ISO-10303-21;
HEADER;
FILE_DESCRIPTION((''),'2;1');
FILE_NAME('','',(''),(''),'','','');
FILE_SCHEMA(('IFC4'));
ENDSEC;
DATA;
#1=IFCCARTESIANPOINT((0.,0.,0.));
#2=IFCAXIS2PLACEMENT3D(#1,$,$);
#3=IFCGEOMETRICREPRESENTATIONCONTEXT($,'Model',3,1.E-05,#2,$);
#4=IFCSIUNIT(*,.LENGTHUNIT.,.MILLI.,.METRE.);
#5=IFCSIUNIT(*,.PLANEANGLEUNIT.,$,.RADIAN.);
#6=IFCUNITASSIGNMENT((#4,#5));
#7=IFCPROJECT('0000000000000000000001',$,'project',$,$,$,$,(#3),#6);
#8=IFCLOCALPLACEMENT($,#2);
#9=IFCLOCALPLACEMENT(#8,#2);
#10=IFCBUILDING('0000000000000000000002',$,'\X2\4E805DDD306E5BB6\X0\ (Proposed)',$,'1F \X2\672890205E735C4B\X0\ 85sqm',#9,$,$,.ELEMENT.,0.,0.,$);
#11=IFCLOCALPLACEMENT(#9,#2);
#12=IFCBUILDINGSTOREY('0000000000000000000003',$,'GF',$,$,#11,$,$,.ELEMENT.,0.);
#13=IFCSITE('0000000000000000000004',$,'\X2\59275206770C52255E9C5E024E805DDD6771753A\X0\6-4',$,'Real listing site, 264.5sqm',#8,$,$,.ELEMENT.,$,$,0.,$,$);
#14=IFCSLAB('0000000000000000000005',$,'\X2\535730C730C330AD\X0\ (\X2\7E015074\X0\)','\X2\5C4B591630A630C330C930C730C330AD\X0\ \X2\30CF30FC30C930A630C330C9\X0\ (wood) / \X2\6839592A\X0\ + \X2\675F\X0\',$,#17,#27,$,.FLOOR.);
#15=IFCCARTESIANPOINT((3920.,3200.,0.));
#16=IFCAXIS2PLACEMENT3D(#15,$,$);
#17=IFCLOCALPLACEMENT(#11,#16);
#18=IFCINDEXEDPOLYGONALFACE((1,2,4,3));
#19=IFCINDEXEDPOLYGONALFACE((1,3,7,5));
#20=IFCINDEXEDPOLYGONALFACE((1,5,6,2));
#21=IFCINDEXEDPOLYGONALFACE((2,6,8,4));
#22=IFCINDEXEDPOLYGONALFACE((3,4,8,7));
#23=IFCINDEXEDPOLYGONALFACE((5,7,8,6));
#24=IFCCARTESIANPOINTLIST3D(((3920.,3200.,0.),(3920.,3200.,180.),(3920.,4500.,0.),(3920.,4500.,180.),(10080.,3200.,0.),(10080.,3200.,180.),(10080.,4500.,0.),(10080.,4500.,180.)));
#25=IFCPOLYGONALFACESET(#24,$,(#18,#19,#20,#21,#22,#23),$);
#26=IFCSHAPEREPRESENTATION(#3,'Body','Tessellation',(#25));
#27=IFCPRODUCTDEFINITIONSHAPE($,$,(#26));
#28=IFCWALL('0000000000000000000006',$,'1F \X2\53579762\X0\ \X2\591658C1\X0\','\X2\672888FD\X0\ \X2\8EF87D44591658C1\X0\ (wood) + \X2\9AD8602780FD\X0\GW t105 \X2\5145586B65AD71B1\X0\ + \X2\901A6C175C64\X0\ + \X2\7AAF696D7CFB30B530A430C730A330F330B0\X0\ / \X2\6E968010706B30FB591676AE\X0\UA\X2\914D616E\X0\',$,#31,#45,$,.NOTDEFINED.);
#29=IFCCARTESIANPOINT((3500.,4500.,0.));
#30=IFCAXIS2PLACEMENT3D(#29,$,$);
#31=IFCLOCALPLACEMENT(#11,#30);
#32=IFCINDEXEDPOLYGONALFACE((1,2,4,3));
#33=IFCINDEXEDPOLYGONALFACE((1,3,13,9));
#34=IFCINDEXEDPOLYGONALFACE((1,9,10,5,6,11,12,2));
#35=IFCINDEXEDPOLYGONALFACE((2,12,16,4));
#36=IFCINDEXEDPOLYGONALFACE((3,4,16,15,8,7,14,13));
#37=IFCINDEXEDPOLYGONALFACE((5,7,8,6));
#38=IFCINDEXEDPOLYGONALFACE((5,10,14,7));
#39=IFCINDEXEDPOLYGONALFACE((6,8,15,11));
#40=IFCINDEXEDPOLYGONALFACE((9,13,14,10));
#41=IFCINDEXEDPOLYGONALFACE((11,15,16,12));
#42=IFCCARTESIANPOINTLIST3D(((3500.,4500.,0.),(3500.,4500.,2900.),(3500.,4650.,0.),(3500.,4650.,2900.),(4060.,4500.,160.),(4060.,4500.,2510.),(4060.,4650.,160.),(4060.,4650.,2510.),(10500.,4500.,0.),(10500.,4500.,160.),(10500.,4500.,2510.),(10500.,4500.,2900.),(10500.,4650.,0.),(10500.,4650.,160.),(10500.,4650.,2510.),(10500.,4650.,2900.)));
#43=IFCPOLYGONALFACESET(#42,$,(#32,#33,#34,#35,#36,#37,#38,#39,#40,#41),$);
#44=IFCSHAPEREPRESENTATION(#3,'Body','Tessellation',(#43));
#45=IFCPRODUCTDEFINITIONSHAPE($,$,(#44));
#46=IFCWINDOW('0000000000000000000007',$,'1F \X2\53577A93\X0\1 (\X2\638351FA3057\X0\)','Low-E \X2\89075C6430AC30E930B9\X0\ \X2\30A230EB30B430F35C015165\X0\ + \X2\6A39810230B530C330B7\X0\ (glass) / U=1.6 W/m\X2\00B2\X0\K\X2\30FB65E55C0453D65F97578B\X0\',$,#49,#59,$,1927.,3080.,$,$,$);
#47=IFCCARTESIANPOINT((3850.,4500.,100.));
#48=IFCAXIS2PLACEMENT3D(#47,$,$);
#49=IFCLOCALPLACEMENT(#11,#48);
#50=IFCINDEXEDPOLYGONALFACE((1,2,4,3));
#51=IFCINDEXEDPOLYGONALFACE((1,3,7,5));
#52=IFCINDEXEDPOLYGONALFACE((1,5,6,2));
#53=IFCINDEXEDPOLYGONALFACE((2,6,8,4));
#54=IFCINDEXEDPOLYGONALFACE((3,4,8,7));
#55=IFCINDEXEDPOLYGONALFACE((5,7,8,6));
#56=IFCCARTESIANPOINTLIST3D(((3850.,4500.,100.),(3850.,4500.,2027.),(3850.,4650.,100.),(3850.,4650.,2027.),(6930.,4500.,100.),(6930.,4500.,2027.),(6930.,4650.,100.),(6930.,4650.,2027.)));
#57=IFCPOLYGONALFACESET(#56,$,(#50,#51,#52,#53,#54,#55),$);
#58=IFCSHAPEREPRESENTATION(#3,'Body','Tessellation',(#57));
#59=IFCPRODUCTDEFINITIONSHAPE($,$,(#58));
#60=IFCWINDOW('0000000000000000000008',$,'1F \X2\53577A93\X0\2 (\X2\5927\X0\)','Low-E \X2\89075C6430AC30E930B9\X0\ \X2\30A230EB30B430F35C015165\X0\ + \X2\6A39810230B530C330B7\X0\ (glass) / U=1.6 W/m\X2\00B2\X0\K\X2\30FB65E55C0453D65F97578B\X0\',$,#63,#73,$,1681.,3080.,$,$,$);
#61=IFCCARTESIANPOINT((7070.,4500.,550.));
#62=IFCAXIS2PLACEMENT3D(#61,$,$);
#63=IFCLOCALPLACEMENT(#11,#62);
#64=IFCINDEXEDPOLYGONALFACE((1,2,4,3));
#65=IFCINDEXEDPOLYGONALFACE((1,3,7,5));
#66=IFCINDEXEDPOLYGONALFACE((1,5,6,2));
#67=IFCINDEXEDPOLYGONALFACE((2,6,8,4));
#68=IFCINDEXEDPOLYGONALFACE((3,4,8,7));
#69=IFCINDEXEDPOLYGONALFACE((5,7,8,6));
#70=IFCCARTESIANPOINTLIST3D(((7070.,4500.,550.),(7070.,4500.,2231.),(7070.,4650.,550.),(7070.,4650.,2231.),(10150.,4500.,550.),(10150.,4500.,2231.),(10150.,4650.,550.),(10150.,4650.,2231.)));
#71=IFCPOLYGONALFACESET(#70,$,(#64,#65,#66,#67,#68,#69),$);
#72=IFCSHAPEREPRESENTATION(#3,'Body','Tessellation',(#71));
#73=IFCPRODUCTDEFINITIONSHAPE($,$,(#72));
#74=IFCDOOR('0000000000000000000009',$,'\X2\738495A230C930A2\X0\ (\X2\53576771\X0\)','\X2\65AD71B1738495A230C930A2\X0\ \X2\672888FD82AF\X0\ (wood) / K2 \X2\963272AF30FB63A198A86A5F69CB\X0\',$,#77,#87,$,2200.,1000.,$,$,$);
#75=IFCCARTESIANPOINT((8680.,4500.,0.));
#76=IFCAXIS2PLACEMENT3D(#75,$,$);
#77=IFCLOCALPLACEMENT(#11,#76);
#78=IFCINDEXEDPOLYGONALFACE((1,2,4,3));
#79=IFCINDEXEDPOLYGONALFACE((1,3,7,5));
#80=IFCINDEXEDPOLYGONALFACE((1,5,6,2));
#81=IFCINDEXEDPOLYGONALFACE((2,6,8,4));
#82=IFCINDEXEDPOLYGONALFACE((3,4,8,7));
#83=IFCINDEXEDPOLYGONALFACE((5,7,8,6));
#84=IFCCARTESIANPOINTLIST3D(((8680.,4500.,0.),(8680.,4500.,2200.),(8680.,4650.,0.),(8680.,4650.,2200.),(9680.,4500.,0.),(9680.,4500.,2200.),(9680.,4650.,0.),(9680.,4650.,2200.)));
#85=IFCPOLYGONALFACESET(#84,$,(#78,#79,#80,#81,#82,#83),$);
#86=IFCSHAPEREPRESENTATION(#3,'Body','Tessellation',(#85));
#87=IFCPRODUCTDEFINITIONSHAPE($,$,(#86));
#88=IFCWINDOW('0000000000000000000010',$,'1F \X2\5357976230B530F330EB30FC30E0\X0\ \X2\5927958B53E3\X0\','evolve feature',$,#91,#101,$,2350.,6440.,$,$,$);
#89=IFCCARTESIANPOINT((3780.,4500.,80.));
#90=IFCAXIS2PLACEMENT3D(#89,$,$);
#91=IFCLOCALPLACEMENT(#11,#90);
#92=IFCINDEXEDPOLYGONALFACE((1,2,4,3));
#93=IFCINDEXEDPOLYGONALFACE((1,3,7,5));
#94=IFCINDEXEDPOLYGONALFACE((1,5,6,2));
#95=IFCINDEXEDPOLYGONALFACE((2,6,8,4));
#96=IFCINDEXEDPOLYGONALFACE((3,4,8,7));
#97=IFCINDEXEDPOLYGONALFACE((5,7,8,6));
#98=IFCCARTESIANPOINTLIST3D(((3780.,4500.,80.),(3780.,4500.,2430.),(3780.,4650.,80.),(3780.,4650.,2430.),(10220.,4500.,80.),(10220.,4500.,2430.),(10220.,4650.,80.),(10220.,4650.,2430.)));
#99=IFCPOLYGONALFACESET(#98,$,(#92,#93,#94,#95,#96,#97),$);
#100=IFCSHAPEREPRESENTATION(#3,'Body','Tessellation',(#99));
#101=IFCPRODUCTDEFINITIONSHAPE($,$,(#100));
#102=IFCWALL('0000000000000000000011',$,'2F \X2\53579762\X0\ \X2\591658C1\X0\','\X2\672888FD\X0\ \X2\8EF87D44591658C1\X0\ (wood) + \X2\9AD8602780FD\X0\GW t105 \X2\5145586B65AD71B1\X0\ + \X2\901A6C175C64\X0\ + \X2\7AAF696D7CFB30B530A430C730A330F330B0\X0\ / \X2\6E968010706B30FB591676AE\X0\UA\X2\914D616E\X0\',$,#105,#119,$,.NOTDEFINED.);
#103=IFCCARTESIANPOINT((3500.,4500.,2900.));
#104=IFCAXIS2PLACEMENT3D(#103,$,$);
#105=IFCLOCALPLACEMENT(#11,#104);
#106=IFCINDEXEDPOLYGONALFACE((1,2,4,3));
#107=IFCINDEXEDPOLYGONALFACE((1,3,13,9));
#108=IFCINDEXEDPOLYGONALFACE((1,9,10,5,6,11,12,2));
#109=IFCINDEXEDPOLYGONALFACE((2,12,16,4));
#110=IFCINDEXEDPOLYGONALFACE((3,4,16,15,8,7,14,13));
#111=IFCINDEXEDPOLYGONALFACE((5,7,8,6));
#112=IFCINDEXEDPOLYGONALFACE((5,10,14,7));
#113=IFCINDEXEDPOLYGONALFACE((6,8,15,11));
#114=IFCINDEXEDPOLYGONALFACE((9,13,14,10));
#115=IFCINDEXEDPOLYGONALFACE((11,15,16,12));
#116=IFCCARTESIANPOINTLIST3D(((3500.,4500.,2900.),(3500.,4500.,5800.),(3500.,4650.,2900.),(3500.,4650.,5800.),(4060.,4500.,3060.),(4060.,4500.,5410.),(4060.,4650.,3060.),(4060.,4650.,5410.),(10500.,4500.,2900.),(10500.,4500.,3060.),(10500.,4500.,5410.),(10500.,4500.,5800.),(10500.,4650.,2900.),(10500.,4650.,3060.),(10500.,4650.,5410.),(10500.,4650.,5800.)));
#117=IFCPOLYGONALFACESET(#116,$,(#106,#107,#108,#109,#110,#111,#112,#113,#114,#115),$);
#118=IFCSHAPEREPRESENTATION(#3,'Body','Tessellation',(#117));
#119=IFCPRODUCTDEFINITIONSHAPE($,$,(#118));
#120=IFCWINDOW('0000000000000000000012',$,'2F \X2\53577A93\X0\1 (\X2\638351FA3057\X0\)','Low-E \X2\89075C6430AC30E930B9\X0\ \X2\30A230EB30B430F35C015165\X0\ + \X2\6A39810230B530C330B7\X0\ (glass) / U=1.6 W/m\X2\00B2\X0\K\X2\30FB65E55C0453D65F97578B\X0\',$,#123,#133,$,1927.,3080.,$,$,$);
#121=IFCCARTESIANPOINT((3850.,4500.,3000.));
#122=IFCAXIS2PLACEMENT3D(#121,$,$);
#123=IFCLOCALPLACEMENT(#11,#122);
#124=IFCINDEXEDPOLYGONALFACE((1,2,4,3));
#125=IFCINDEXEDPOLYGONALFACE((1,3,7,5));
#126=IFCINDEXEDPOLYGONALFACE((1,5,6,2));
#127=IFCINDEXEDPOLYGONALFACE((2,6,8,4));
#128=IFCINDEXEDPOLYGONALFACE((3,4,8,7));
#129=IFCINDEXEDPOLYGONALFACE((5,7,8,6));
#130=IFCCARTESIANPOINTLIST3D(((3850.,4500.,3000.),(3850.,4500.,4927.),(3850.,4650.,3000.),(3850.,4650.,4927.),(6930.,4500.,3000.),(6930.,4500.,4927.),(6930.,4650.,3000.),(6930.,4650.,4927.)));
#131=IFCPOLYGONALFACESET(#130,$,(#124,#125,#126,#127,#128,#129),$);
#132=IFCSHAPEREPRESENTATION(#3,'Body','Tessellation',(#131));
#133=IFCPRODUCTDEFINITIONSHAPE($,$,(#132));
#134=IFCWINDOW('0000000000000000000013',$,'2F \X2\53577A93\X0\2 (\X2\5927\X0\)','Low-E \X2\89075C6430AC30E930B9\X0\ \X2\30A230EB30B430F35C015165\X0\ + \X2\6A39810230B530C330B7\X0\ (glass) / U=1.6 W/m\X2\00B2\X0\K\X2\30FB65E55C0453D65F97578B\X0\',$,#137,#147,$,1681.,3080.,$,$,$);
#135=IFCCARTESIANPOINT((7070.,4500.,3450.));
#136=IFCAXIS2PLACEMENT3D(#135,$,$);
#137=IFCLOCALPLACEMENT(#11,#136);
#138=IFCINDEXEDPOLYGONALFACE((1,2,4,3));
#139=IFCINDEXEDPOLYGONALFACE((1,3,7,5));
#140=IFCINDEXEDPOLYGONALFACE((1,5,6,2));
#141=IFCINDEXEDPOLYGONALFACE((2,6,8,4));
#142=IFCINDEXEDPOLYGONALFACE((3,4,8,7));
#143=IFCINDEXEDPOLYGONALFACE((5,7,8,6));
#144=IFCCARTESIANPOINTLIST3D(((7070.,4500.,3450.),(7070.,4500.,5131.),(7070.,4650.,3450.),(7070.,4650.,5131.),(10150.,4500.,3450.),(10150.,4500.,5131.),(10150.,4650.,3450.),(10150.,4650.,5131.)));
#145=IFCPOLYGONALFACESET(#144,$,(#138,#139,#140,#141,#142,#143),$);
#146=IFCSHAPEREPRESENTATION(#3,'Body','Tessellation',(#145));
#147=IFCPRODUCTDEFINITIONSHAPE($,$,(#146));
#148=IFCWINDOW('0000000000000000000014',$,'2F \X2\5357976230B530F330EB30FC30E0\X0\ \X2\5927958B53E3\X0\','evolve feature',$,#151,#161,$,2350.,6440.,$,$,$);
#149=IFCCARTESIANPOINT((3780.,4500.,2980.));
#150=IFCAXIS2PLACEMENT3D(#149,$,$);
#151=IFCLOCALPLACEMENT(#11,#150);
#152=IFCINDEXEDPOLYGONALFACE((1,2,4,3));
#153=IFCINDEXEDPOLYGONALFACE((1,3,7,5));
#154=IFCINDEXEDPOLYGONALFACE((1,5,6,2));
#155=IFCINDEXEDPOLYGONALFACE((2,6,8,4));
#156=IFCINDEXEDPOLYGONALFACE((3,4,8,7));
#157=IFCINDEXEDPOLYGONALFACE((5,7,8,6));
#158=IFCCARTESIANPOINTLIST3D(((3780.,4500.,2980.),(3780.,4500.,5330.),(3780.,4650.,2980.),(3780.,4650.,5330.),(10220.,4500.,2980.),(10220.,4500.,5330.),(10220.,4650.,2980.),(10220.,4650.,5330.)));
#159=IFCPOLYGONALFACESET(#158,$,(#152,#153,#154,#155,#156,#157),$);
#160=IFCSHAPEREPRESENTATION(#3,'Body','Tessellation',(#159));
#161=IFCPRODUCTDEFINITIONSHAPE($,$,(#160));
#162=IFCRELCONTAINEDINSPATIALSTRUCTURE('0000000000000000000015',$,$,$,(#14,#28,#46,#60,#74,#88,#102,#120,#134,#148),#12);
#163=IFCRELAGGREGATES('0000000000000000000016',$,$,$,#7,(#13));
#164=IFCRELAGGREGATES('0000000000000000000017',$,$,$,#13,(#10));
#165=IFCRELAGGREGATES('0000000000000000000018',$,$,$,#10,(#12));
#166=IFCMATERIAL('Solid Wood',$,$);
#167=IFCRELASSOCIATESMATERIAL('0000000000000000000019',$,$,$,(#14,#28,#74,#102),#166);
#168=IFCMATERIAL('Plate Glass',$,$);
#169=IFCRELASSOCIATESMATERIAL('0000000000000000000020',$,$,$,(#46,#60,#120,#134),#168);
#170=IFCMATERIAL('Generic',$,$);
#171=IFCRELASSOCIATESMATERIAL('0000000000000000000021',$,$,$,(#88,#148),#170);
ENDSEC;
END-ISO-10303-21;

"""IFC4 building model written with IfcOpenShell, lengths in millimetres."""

from ifc_helpers import new_model, si_unit, frame, frame_2d, origin, place, context, project, spatial, rectangle, extrude, material, element, fill, save


model = new_model("IFC4")

# Units and contexts
model_context = context("Model", 3, precision=1e-05, world=origin())
ifc_project = project(units=[si_unit("LENGTHUNIT", "METRE", prefix="MILLI"), si_unit("PLANEANGLEUNIT", "RADIAN")], contexts=[model_context])

# Site, building, storey
site_placement = place(None, origin())
site = spatial("IfcSite", under=ifc_project, at=site_placement, Name="大分県別府市亀川東町6-4", ObjectType="Real listing site, 264.5sqm", CompositionType="ELEMENT", RefElevation=0.0)
building_placement = place(site_placement, origin())
building = spatial("IfcBuilding", under=site, at=building_placement, Name="亀川の家 (Proposed)", ObjectType="1F 木造平屋 85sqm", CompositionType="ELEMENT", ElevationOfRefHeight=0.0, ElevationOfTerrain=0.0)
storey_placement = place(building_placement, origin())
storey = spatial("IfcBuildingStorey", under=building, at=storey_placement, Name="GF", CompositionType="ELEMENT", Elevation=0.0)

# Slab
ifc_material_1 = material(Name="Solid Wood")
slab_1_placement = place(storey_placement, frame((3920.0, 3200.0, 0.0)))
element("IfcSlab", 1, at=slab_1_placement, inside=storey, material=ifc_material_1, Name="南デッキ (縁側)", Description="屋外ウッドデッキ ハードウッド (wood) / 根太 + 束", PredefinedType="FLOOR", context=model_context, shape_type="SweptSolid", body=[
    extrude(rectangle(XDim=6160.0, YDim=1300.0, at=frame_2d((3080.0, 650.0))), frame((3920.0, 3200.0, 0.0)), (0.0, 0.0, 1.0), 180.0),
])
ifc_material_2 = material(Name="Generic")

# Wall, openings, windows, door
wall_1_placement = place(storey_placement, frame((3500.0, 4500.0, 0.0)))
wall_1 = element("IfcWall", 2, at=wall_1_placement, inside=storey, material=ifc_material_1, Name="1F 南面 外壁", Description="木製 軸組外壁 (wood) + 高性能GW t105 充填断熱 + 通気層 + 窯業系サイディング / 準耐火・外皮UA配慮", PredefinedType="NOTDEFINED", context=model_context, shape_type="SweptSolid", body=[
    extrude(rectangle(XDim=7000.0, YDim=150.0, at=frame_2d((3500.0, 75.0))), frame((3500.0, 4500.0, 0.0)), (0.0, 0.0, 1.0), 2900.0),
])
opening_1_placement = place(storey_placement, frame((3850.0, 4500.0, 100.0)))
opening_1 = element("IfcOpeningElement", 3, at=opening_1_placement, cuts=wall_1, PredefinedType="NOTDEFINED", context=model_context, shape_type="SweptSolid", body=[
    extrude(rectangle(XDim=3080.0, YDim=150.0, at=frame_2d((1540.0, 75.0))), frame((3850.0, 4500.0, 100.0)), (0.0, 0.0, 1.0), 1927.0),
])
opening_2_placement = place(storey_placement, frame((7070.0, 4500.0, 550.0)))
opening_2 = element("IfcOpeningElement", 4, at=opening_2_placement, cuts=wall_1, PredefinedType="NOTDEFINED", context=model_context, shape_type="SweptSolid", body=[
    extrude(rectangle(XDim=3080.0, YDim=150.0, at=frame_2d((1540.0, 75.0))), frame((7070.0, 4500.0, 550.0)), (0.0, 0.0, 1.0), 1681.0),
])
opening_3_placement = place(storey_placement, frame((8680.0, 4500.0, 0.0)))
opening_3 = element("IfcOpeningElement", 5, at=opening_3_placement, cuts=wall_1, PredefinedType="NOTDEFINED", context=model_context, shape_type="SweptSolid", body=[
    extrude(rectangle(XDim=1000.0, YDim=150.0, at=frame_2d((500.0, 75.0))), frame((8680.0, 4500.0, 0.0)), (0.0, 0.0, 1.0), 2200.0),
])
opening_4_placement = place(storey_placement, frame((3780.0, 4500.0, 80.0)))
opening_4 = element("IfcOpeningElement", 6, at=opening_4_placement, cuts=wall_1, PredefinedType="NOTDEFINED", context=model_context, shape_type="SweptSolid", body=[
    extrude(rectangle(XDim=6440.0, YDim=150.0, at=frame_2d((3220.0, 75.0))), frame((3780.0, 4500.0, 80.0)), (0.0, 0.0, 1.0), 2350.0),
])
ifc_material_3 = material(Name="Plate Glass")
window_1_placement = place(storey_placement, frame((3850.0, 4500.0, 100.0)))
window_1 = element("IfcWindow", 7, at=window_1_placement, inside=storey, material=ifc_material_3, Name="1F 南窓1 (掃出し)", Description="Low-E 複層ガラス アルゴン封入 + 樹脂サッシ (glass) / U=1.6 W/m²K・日射取得型", OverallHeight=1927.0, OverallWidth=3080.0, context=model_context, shape_type="SweptSolid", body=[
    extrude(rectangle(XDim=3080.0, YDim=150.0, at=frame_2d((1540.0, 75.0))), frame((3850.0, 4500.0, 100.0)), (0.0, 0.0, 1.0), 1927.0),
])
fill(opening_1, window_1)
window_2_placement = place(storey_placement, frame((7070.0, 4500.0, 550.0)))
window_2 = element("IfcWindow", 8, at=window_2_placement, inside=storey, material=ifc_material_3, Name="1F 南窓2 (大)", Description="Low-E 複層ガラス アルゴン封入 + 樹脂サッシ (glass) / U=1.6 W/m²K・日射取得型", OverallHeight=1681.0, OverallWidth=3080.0, context=model_context, shape_type="SweptSolid", body=[
    extrude(rectangle(XDim=3080.0, YDim=150.0, at=frame_2d((1540.0, 75.0))), frame((7070.0, 4500.0, 550.0)), (0.0, 0.0, 1.0), 1681.0),
])
fill(opening_2, window_2)
door_placement = place(storey_placement, frame((8680.0, 4500.0, 0.0)))
door = element("IfcDoor", 9, at=door_placement, inside=storey, material=ifc_material_1, Name="玄関ドア (南東)", Description="断熱玄関ドア 木製芯 (wood) / K2 防犯・採風機構", OverallHeight=2200.0, OverallWidth=1000.0, context=model_context, shape_type="SweptSolid", body=[
    extrude(rectangle(XDim=1000.0, YDim=150.0, at=frame_2d((500.0, 75.0))), frame((8680.0, 4500.0, 0.0)), (0.0, 0.0, 1.0), 2200.0),
])
fill(opening_3, door)
window_3_placement = place(storey_placement, frame((3780.0, 4500.0, 80.0)))
window_3 = element("IfcWindow", 10, at=window_3_placement, inside=storey, material=ifc_material_2, Name="1F 南面サンルーム 大開口", Description="evolve feature", OverallHeight=2350.0, OverallWidth=6440.0, context=model_context, shape_type="SweptSolid", body=[
    extrude(rectangle(XDim=6440.0, YDim=150.0, at=frame_2d((3220.0, 75.0))), frame((3780.0, 4500.0, 80.0)), (0.0, 0.0, 1.0), 2350.0),
])
fill(opening_4, window_3)

# Wall, openings, windows
wall_2_placement = place(storey_placement, frame((3500.0, 4500.0, 2900.0)))
wall_2 = element("IfcWall", 11, at=wall_2_placement, inside=storey, material=ifc_material_1, Name="2F 南面 外壁", Description="木製 軸組外壁 (wood) + 高性能GW t105 充填断熱 + 通気層 + 窯業系サイディング / 準耐火・外皮UA配慮", PredefinedType="NOTDEFINED", context=model_context, shape_type="SweptSolid", body=[
    extrude(rectangle(XDim=7000.0, YDim=150.0, at=frame_2d((3500.0, 75.0))), frame((3500.0, 4500.0, 2900.0)), (0.0, 0.0, 1.0), 2900.0),
])
opening_5_placement = place(storey_placement, frame((3850.0, 4500.0, 3000.0)))
opening_5 = element("IfcOpeningElement", 12, at=opening_5_placement, cuts=wall_2, PredefinedType="NOTDEFINED", context=model_context, shape_type="SweptSolid", body=[
    extrude(rectangle(XDim=3080.0, YDim=150.0, at=frame_2d((1540.0, 75.0))), frame((3850.0, 4500.0, 3000.0)), (0.0, 0.0, 1.0), 1927.0),
])
opening_6_placement = place(storey_placement, frame((7070.0, 4500.0, 3450.0)))
opening_6 = element("IfcOpeningElement", 13, at=opening_6_placement, cuts=wall_2, PredefinedType="NOTDEFINED", context=model_context, shape_type="SweptSolid", body=[
    extrude(rectangle(XDim=3080.0, YDim=150.0, at=frame_2d((1540.0, 75.0))), frame((7070.0, 4500.0, 3450.0)), (0.0, 0.0, 1.0), 1681.0),
])
opening_7_placement = place(storey_placement, frame((3780.0, 4500.0, 2980.0)))
opening_7 = element("IfcOpeningElement", 14, at=opening_7_placement, cuts=wall_2, PredefinedType="NOTDEFINED", context=model_context, shape_type="SweptSolid", body=[
    extrude(rectangle(XDim=6440.0, YDim=150.0, at=frame_2d((3220.0, 75.0))), frame((3780.0, 4500.0, 2980.0)), (0.0, 0.0, 1.0), 2350.0),
])
window_4_placement = place(storey_placement, frame((3850.0, 4500.0, 3000.0)))
window_4 = element("IfcWindow", 15, at=window_4_placement, inside=storey, material=ifc_material_3, Name="2F 南窓1 (掃出し)", Description="Low-E 複層ガラス アルゴン封入 + 樹脂サッシ (glass) / U=1.6 W/m²K・日射取得型", OverallHeight=1927.0, OverallWidth=3080.0, context=model_context, shape_type="SweptSolid", body=[
    extrude(rectangle(XDim=3080.0, YDim=150.0, at=frame_2d((1540.0, 75.0))), frame((3850.0, 4500.0, 3000.0)), (0.0, 0.0, 1.0), 1927.0),
])
fill(opening_5, window_4)
window_5_placement = place(storey_placement, frame((7070.0, 4500.0, 3450.0)))
window_5 = element("IfcWindow", 16, at=window_5_placement, inside=storey, material=ifc_material_3, Name="2F 南窓2 (大)", Description="Low-E 複層ガラス アルゴン封入 + 樹脂サッシ (glass) / U=1.6 W/m²K・日射取得型", OverallHeight=1681.0, OverallWidth=3080.0, context=model_context, shape_type="SweptSolid", body=[
    extrude(rectangle(XDim=3080.0, YDim=150.0, at=frame_2d((1540.0, 75.0))), frame((7070.0, 4500.0, 3450.0)), (0.0, 0.0, 1.0), 1681.0),
])
fill(opening_6, window_5)
window_6_placement = place(storey_placement, frame((3780.0, 4500.0, 2980.0)))
window_6 = element("IfcWindow", 17, at=window_6_placement, inside=storey, material=ifc_material_2, Name="2F 南面サンルーム 大開口", Description="evolve feature", OverallHeight=2350.0, OverallWidth=6440.0, context=model_context, shape_type="SweptSolid", body=[
    extrude(rectangle(XDim=6440.0, YDim=150.0, at=frame_2d((3220.0, 75.0))), frame((3780.0, 4500.0, 2980.0)), (0.0, 0.0, 1.0), 2350.0),
])
fill(opening_7, window_6)

save(model, "model.ifc")
